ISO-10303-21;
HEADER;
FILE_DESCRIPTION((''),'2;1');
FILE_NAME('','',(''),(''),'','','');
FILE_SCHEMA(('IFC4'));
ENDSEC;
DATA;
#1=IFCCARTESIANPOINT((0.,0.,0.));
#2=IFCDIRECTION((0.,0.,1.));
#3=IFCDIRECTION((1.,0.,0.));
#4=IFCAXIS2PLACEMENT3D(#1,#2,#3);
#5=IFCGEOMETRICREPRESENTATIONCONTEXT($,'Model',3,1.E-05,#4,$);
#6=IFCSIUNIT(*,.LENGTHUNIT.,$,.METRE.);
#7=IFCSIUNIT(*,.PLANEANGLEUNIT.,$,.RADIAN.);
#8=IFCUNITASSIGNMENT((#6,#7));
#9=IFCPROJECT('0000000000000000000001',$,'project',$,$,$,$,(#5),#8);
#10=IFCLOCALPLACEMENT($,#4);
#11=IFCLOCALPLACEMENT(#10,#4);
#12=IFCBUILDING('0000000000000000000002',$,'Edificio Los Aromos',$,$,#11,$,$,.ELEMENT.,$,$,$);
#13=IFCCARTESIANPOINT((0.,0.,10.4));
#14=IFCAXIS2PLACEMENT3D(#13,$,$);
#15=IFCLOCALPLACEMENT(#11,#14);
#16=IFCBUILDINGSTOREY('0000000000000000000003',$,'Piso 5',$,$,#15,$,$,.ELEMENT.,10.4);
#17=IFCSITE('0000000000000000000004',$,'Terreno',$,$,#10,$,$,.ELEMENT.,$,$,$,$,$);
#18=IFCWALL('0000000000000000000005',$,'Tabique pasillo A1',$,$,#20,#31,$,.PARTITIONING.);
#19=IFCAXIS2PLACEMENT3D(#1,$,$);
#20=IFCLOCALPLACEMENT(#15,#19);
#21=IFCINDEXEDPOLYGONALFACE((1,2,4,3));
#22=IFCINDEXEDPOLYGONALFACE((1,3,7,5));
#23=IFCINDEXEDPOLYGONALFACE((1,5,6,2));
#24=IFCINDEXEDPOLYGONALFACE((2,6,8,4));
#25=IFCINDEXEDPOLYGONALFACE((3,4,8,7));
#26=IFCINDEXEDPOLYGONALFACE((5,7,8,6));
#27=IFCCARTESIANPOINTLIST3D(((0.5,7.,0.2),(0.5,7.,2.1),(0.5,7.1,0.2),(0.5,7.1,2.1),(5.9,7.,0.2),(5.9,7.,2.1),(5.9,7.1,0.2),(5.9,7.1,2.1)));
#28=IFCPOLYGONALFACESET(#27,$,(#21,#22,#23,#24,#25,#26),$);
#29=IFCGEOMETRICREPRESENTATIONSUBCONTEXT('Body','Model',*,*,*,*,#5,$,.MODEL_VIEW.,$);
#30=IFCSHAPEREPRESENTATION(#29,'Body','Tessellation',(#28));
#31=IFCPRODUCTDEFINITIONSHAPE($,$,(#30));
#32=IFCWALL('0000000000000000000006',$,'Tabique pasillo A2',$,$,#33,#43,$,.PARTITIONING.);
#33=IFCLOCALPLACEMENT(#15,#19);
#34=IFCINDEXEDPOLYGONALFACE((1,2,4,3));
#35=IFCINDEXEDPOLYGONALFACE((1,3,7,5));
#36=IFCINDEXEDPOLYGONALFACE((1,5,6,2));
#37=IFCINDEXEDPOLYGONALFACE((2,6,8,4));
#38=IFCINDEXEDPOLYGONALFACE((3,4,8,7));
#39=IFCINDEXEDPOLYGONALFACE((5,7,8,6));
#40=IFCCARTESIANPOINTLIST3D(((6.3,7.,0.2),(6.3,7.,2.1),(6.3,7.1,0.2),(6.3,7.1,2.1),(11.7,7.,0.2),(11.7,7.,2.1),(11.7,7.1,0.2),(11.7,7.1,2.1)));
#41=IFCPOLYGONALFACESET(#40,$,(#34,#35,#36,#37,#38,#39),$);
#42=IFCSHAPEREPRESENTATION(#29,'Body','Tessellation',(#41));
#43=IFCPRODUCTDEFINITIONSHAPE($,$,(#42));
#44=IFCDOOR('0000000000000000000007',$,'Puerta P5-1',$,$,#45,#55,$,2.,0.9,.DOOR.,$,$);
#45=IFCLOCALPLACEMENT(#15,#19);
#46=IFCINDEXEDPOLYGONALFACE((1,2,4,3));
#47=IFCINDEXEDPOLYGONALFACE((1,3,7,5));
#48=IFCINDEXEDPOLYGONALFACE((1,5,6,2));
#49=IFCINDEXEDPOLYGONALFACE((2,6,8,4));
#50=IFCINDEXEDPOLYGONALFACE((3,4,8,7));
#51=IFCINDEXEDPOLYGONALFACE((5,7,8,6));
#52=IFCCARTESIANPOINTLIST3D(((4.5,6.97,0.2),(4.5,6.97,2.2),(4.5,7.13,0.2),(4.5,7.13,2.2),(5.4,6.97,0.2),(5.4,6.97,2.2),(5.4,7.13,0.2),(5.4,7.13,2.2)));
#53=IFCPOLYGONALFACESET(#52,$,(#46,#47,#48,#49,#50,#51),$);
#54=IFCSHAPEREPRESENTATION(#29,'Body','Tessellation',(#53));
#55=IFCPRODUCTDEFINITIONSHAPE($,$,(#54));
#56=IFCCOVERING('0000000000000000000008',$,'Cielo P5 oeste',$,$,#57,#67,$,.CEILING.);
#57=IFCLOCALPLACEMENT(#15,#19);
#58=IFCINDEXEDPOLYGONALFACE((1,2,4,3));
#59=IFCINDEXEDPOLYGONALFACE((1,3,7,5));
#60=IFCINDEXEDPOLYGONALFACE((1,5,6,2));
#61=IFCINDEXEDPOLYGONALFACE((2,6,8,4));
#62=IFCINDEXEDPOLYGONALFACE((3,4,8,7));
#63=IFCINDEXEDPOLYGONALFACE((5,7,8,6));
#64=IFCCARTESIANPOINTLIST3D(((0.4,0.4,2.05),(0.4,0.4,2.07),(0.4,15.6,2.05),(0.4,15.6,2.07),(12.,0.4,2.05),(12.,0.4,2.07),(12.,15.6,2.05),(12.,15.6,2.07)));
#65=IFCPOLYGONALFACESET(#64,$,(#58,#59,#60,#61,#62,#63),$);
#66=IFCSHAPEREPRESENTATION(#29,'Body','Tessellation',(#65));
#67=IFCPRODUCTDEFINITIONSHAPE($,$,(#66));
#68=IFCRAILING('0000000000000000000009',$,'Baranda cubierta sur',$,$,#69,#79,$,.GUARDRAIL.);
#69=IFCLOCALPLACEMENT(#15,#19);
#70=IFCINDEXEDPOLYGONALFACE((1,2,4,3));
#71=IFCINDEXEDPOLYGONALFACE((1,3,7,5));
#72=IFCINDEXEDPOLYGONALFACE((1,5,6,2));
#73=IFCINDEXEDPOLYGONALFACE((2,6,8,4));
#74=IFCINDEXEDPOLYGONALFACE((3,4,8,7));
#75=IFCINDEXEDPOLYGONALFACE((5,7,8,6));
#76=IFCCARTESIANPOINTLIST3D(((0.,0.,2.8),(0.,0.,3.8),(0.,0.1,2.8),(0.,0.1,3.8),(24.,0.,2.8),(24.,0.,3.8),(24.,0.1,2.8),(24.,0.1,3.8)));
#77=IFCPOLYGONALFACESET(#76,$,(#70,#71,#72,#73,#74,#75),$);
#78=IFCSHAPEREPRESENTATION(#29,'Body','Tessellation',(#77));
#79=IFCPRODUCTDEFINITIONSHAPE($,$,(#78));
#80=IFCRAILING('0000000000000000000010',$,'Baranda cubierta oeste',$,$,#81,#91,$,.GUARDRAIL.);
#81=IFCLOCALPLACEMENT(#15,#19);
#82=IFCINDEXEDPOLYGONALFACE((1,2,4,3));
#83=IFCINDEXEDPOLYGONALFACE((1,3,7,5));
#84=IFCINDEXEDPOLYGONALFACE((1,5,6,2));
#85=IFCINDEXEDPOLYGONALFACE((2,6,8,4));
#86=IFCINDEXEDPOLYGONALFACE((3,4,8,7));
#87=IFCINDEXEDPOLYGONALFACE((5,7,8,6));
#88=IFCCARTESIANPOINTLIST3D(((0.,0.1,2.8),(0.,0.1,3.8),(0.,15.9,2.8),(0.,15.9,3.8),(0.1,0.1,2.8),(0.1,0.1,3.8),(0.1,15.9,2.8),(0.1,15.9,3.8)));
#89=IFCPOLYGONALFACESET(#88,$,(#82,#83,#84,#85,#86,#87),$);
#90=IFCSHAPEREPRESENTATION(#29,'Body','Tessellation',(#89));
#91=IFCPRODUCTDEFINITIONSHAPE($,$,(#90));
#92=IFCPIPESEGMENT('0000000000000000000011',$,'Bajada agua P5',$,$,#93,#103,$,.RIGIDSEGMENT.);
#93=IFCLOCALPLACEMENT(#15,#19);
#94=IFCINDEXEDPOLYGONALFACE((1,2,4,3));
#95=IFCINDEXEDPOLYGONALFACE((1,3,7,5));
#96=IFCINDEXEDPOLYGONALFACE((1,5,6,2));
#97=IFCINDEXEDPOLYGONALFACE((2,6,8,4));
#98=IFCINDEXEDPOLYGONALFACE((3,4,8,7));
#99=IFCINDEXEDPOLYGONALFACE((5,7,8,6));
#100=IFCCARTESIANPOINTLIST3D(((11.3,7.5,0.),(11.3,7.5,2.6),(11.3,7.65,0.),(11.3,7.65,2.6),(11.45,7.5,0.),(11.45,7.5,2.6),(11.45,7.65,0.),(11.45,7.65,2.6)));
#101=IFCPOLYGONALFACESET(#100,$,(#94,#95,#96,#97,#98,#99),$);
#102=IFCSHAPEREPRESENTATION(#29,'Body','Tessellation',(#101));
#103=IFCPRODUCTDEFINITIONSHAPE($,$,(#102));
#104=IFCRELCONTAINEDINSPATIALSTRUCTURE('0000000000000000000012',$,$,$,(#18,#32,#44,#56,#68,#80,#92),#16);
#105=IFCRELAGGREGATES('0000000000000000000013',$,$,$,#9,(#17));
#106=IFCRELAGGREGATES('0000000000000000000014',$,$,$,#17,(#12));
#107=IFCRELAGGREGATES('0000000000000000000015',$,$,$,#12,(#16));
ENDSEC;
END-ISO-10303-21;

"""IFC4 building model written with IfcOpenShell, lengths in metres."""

from ifc_helpers import new_model, si_unit, frame, frame_2d, origin_with_axes, place, context, subcontext, project, spatial, rectangle, extrude, element, save


model = new_model("IFC4")

# Units and contexts
model_context = context("Model", 3, precision=1e-05, world=origin_with_axes())
body_context = subcontext(model_context, "Body", "Model", "MODEL_VIEW")
ifc_project = project(units=[si_unit("LENGTHUNIT", "METRE"), si_unit("PLANEANGLEUNIT", "RADIAN")], contexts=[model_context])

# Site, building, storey
site_placement = place(None, origin_with_axes())
site = spatial("IfcSite", under=ifc_project, at=site_placement, Name="Terreno", CompositionType="ELEMENT")
building_placement = place(site_placement, origin_with_axes())
building = spatial("IfcBuilding", under=site, at=building_placement, Name="Edificio Los Aromos", CompositionType="ELEMENT")
storey_placement = place(building_placement, frame((0.0, 0.0, 10.4)))
storey = spatial("IfcBuildingStorey", under=building, at=storey_placement, Name="Piso 5", CompositionType="ELEMENT", Elevation=10.4)

# Walls
for number, where, name in (
    (1, (0.5, 7.0, 0.2), "Tabique pasillo A1"),
    (2, (6.3, 7.0, 0.2), "Tabique pasillo A2"),
):
    element("IfcWall", number, at=place(storey_placement, frame(where)), inside=storey, Name=name, PredefinedType="PARTITIONING", context=body_context, shape_type="SweptSolid", body=[
        extrude(rectangle(XDim=5.4, YDim=0.1, at=frame_2d((2.7, 0.05))), origin_with_axes(), (0.0, 0.0, 1.0), 1.9),
    ])

# Door
door_placement = place(storey_placement, frame((4.5, 6.97, 0.2)))
element("IfcDoor", 3, at=door_placement, inside=storey, Name="Puerta P5-1", OverallHeight=2.0, OverallWidth=0.9, PredefinedType="DOOR", context=body_context, shape_type="SweptSolid", body=[
    extrude(rectangle(XDim=0.9, YDim=0.16, at=frame_2d((0.45, 0.08))), origin_with_axes(), (0.0, 0.0, 1.0), 2.0),
])

# Covering
covering_placement = place(storey_placement, frame((0.4, 0.4, 2.05)))
element("IfcCovering", 4, at=covering_placement, inside=storey, Name="Cielo P5 oeste", PredefinedType="CEILING", context=body_context, shape_type="SweptSolid", body=[
    extrude(rectangle(XDim=11.6, YDim=15.2, at=frame_2d((5.8, 7.6))), origin_with_axes(), (0.0, 0.0, 1.0), 0.02),
])

# Railings
railing_1_placement = place(storey_placement, frame((0.0, 0.0, 2.8)))
element("IfcRailing", 5, at=railing_1_placement, inside=storey, Name="Baranda cubierta sur", PredefinedType="GUARDRAIL", context=body_context, shape_type="SweptSolid", body=[
    extrude(rectangle(XDim=24.0, YDim=0.1, at=frame_2d((12.0, 0.05))), origin_with_axes(), (0.0, 0.0, 1.0), 1.0),
])
railing_2_placement = place(storey_placement, frame((0.0, 0.1, 2.8)))
element("IfcRailing", 6, at=railing_2_placement, inside=storey, Name="Baranda cubierta oeste", PredefinedType="GUARDRAIL", context=body_context, shape_type="SweptSolid", body=[
    extrude(rectangle(XDim=0.1, YDim=15.8, at=frame_2d((0.05, 7.9))), origin_with_axes(), (0.0, 0.0, 1.0), 1.0),
])

# Pipe segment
pipe_segment_placement = place(storey_placement, frame((11.3, 7.5, 0.0)))
element("IfcPipeSegment", 7, at=pipe_segment_placement, inside=storey, Name="Bajada agua P5", PredefinedType="RIGIDSEGMENT", context=body_context, shape_type="SweptSolid", body=[
    extrude(rectangle(XDim=0.15, YDim=0.15, at=frame_2d((0.075, 0.075))), origin_with_axes(), (0.0, 0.0, 1.0), 2.6),
])

save(model, "model.ifc")
